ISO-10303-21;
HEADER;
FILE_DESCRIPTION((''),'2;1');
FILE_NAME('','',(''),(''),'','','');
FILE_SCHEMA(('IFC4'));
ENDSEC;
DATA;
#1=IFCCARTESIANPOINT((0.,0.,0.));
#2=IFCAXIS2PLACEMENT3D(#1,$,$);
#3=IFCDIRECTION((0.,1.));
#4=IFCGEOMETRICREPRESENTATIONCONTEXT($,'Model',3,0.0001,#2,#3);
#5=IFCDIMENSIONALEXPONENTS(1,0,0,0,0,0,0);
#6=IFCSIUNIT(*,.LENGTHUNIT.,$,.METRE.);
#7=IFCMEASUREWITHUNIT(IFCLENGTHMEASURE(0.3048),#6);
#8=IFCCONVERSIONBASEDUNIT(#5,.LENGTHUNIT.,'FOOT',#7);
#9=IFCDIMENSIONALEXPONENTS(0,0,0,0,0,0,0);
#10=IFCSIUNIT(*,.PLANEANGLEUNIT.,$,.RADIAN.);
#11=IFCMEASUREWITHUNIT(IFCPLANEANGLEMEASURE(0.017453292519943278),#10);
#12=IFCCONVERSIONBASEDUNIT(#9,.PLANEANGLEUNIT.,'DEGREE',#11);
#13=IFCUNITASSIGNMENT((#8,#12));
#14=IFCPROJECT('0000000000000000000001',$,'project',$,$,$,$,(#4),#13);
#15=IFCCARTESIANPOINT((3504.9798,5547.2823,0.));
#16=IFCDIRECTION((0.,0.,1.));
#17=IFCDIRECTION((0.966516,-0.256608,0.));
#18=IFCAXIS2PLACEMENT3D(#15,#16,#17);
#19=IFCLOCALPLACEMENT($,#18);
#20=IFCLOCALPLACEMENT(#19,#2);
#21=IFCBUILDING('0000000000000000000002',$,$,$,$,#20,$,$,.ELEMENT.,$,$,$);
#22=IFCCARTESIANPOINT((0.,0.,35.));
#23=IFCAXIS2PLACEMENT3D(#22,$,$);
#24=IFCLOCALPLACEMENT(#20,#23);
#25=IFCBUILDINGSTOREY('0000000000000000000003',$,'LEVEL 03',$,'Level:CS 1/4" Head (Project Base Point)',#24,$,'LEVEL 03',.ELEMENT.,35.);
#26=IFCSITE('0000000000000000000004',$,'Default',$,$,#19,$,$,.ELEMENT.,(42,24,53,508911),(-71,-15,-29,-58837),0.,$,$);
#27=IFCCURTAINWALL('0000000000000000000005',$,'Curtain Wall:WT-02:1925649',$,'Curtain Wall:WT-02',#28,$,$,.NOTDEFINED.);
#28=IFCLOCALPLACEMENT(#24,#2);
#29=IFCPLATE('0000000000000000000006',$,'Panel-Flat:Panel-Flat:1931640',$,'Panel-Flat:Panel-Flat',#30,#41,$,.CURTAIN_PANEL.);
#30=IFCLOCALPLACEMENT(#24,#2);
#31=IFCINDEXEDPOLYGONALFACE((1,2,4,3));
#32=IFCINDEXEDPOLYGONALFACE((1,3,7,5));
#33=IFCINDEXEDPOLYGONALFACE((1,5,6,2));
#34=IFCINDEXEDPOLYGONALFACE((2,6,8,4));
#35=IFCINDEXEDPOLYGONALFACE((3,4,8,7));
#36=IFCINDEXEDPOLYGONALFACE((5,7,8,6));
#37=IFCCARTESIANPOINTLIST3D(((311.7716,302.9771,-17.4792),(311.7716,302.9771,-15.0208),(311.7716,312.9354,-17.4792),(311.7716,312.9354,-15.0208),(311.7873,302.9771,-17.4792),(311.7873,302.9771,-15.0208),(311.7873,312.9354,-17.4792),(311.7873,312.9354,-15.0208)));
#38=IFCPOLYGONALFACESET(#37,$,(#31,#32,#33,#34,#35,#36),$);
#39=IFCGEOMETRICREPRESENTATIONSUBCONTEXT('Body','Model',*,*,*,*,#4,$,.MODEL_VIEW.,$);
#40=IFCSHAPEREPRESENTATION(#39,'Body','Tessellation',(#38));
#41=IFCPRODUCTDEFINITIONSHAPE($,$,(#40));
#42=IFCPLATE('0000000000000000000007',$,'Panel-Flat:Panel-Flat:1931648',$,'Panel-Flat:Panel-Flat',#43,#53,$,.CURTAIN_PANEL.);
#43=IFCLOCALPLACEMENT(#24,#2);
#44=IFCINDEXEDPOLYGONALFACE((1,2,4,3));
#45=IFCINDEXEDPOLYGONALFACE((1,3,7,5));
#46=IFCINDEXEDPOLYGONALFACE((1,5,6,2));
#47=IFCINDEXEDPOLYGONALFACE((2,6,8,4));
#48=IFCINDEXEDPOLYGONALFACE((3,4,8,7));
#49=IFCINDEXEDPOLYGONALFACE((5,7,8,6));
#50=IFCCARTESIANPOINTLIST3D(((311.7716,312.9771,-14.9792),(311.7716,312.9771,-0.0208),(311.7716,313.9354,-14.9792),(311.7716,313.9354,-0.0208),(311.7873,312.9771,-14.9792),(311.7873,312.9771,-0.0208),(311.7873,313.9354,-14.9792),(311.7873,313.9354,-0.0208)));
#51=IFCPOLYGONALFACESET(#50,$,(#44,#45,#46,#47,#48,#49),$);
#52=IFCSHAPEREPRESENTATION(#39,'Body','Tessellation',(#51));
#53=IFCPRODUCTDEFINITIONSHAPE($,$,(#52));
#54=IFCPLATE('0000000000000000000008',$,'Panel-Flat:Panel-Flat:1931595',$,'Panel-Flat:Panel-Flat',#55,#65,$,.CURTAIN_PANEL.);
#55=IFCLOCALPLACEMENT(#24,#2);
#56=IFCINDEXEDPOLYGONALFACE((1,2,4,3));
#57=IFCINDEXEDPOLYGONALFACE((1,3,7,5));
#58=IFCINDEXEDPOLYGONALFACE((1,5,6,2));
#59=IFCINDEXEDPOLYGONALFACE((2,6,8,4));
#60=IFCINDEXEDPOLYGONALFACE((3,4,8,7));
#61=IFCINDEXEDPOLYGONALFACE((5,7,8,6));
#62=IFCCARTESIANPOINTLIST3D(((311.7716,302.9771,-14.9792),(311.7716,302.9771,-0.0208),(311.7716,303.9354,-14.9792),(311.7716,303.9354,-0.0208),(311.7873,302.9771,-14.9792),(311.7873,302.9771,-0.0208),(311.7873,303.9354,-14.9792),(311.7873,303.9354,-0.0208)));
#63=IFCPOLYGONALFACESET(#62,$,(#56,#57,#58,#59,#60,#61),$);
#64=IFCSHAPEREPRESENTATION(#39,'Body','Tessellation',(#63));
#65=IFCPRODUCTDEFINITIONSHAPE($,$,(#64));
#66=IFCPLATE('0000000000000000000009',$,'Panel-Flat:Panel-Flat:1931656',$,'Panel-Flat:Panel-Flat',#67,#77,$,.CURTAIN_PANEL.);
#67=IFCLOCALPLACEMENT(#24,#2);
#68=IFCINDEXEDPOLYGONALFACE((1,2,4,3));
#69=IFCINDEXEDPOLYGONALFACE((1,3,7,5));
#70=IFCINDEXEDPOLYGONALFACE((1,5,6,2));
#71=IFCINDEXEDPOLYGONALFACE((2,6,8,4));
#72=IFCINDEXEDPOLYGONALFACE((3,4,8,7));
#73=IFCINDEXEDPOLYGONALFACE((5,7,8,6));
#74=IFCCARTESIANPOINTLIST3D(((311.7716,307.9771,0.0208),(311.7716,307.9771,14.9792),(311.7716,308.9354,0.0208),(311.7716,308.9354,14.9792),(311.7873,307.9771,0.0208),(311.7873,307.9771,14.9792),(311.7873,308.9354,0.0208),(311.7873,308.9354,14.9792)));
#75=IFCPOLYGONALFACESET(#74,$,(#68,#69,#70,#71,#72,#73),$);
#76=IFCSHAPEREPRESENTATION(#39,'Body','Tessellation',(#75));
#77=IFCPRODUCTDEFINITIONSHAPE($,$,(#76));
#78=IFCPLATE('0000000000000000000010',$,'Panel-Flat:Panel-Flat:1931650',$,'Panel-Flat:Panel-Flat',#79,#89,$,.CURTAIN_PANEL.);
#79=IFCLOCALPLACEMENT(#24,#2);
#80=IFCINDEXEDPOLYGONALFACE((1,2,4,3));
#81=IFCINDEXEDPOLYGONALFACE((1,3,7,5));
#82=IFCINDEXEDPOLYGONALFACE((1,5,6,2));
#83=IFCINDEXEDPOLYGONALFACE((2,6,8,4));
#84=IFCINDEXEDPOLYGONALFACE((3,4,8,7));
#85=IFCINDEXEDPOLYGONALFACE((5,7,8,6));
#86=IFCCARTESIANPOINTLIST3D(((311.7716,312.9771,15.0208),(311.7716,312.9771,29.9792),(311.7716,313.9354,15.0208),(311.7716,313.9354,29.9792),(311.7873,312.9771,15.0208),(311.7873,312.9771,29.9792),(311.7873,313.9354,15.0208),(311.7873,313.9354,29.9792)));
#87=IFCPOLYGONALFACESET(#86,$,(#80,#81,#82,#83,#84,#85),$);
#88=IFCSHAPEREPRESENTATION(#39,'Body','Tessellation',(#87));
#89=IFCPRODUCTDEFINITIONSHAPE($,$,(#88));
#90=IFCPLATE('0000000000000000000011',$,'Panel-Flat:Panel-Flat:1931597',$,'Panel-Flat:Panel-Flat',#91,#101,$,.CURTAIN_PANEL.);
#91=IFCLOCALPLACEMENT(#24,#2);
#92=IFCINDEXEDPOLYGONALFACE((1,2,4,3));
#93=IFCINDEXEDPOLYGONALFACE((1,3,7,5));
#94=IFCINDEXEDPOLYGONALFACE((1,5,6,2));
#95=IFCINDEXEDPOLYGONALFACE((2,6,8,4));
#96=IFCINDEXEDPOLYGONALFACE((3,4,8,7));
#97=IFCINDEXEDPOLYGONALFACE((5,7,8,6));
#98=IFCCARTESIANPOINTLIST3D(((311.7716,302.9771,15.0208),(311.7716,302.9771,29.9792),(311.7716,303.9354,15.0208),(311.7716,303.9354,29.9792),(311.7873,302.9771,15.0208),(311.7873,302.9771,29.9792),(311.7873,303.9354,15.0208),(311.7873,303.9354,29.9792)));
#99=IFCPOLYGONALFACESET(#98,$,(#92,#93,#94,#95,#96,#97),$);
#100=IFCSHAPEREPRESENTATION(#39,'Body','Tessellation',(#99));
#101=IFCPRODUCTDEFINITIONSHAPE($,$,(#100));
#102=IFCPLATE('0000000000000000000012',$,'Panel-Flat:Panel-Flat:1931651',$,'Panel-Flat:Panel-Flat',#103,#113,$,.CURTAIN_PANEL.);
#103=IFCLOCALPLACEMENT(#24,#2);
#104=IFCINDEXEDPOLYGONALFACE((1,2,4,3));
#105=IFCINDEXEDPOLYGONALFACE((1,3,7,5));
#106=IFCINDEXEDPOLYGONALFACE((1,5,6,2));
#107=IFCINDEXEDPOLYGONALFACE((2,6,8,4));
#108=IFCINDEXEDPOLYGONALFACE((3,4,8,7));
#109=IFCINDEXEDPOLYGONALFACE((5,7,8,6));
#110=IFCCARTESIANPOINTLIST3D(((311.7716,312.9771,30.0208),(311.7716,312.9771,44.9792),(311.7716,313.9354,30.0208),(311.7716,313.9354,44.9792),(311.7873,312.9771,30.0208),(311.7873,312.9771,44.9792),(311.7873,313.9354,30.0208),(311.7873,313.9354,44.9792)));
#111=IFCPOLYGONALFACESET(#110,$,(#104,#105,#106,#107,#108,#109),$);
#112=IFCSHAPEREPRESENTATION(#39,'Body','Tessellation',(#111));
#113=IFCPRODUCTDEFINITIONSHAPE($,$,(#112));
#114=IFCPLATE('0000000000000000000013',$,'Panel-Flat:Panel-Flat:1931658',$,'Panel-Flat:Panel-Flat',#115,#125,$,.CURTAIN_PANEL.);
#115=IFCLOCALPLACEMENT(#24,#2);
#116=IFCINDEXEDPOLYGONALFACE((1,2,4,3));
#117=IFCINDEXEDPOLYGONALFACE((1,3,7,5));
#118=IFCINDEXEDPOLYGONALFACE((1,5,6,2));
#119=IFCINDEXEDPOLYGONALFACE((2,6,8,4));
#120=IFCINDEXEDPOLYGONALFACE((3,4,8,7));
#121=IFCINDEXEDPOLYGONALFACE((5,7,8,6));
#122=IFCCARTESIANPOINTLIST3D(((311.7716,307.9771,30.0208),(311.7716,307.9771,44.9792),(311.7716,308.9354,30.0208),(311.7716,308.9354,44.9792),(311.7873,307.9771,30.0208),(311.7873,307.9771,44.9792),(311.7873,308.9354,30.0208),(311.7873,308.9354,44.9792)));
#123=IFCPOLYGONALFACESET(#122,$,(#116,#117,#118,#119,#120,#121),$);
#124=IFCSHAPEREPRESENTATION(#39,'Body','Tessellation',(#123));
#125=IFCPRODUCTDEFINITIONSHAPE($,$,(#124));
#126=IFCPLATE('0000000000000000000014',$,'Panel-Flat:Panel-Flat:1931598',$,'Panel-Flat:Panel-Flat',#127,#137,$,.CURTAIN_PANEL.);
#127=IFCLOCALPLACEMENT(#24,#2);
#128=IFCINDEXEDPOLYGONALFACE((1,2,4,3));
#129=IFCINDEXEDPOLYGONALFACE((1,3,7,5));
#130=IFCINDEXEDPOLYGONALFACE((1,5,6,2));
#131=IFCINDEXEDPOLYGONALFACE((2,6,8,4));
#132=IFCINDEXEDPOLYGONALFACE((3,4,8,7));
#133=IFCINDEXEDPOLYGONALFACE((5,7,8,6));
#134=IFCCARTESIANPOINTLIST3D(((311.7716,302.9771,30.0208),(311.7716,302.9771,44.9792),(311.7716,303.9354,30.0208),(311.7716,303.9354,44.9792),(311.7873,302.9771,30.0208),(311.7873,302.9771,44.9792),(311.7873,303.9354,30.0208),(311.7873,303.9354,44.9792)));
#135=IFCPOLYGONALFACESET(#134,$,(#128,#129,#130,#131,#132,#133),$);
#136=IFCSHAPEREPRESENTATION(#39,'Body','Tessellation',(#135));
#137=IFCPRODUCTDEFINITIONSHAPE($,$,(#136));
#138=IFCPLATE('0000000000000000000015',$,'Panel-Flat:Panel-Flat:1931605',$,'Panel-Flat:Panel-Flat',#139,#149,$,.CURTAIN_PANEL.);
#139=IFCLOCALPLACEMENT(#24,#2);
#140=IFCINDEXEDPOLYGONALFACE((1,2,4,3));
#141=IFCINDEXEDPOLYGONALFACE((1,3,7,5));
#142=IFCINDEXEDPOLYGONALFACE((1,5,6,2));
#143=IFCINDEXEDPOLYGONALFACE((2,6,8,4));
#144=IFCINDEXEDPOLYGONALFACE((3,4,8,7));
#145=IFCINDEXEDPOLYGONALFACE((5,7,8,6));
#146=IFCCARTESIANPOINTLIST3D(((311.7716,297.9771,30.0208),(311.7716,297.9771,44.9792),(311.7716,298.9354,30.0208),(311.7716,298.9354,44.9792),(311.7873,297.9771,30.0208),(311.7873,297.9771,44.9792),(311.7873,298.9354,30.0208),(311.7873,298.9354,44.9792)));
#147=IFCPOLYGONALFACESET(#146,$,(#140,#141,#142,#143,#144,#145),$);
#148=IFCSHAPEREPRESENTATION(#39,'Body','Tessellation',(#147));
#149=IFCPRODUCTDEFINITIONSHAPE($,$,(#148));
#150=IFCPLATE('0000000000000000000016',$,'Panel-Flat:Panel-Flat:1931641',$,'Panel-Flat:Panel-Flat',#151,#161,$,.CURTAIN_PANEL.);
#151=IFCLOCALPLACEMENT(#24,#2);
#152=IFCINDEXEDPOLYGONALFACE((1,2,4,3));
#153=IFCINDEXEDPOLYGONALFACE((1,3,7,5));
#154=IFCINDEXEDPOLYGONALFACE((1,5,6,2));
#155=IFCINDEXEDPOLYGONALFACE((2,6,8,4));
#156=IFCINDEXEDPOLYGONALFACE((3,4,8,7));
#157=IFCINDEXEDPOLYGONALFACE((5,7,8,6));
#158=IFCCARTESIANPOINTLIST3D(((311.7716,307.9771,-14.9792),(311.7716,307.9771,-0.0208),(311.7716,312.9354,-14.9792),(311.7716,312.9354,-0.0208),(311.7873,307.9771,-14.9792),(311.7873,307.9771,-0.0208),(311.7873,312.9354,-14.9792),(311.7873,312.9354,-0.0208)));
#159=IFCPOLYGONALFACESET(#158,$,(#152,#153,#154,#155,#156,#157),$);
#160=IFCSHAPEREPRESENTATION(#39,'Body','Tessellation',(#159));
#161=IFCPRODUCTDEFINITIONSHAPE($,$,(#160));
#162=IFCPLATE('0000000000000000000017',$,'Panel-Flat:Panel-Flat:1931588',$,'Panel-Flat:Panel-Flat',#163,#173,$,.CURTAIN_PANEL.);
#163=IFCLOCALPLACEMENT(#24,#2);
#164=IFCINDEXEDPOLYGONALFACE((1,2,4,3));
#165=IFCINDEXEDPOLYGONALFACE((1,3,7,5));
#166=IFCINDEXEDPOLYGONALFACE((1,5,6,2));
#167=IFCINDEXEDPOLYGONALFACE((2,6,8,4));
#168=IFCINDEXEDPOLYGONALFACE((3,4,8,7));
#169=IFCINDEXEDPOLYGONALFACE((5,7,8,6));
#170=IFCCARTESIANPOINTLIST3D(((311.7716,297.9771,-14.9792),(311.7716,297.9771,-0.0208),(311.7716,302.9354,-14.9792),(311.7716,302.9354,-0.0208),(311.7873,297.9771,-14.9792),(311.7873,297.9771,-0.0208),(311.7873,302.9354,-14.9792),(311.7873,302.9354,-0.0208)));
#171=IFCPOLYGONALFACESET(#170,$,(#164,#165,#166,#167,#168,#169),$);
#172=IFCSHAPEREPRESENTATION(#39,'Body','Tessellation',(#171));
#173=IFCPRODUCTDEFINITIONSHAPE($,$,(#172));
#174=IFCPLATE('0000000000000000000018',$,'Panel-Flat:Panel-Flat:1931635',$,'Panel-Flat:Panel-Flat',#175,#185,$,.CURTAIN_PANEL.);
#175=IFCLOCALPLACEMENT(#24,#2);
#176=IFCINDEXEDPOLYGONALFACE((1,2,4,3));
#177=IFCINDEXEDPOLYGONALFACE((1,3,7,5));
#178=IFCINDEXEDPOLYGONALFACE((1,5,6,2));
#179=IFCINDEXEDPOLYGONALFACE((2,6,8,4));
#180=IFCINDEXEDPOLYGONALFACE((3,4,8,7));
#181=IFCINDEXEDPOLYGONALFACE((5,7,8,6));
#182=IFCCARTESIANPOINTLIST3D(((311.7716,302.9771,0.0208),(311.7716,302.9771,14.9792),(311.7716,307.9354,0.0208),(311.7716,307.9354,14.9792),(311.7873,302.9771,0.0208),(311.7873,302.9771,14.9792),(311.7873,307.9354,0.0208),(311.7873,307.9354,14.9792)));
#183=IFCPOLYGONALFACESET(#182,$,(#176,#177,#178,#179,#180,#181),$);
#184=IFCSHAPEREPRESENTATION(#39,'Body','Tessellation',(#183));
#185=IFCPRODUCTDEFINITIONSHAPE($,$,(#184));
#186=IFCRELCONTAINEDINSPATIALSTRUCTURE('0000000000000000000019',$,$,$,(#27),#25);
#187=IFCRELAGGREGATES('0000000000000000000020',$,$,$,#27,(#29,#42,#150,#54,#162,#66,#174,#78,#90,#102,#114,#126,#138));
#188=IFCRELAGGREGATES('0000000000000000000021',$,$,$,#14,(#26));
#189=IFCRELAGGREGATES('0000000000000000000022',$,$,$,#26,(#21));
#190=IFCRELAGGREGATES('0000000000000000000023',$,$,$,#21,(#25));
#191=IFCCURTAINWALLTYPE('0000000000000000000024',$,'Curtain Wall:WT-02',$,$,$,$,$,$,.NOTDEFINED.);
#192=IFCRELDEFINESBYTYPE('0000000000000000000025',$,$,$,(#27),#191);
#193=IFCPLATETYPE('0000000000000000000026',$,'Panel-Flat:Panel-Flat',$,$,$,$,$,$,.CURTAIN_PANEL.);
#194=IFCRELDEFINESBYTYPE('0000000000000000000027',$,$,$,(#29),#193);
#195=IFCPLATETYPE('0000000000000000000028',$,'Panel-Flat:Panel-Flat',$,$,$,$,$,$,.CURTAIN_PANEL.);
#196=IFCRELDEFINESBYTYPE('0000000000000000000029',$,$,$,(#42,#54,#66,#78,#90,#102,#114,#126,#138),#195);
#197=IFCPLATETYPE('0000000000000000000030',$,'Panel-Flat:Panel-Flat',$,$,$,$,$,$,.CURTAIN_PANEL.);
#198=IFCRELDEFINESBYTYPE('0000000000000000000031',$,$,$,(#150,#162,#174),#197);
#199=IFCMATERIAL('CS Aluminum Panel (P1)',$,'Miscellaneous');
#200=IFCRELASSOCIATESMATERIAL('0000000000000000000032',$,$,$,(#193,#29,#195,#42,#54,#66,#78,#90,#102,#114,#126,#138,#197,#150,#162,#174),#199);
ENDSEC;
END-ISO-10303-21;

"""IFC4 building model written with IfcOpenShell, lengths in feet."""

from ifc_helpers import new_model, entity, si_unit, converted_unit, direction, frame, origin, place, context, subcontext, project, spatial, indexed_curve, outline, extrude, source, transform, mapped, material, type_object, type_shapes, element, aggregate, save


model = new_model("IFC4")

# Units and contexts
model_context = context("Model", 3, precision=0.0001, world=origin(), true_north=direction((0.0, 1.0)))
body_context = subcontext(model_context, "Body", "Model", "MODEL_VIEW")
ifc_project = project(units=[converted_unit("LENGTHUNIT", "FOOT", entity("IfcLengthMeasure", 0.3048), si_unit("LENGTHUNIT", "METRE"), dimensions=[1, 0, 0, 0, 0, 0, 0]), converted_unit("PLANEANGLEUNIT", "DEGREE", entity("IfcPlaneAngleMeasure", 0.017453292519943278), si_unit("PLANEANGLEUNIT", "RADIAN"), dimensions=[0, 0, 0, 0, 0, 0, 0])], contexts=[model_context])

# Site, building, storey
site_placement = place(None, frame((3504.9798, 5547.2823, 0.0), z_axis=(0.0, 0.0, 1.0), x_axis=(0.966516, -0.256608, 0.0)))
site = spatial("IfcSite", under=ifc_project, at=site_placement, Name="Default", CompositionType="ELEMENT", RefLatitude=(42, 24, 53, 508911), RefLongitude=(-71, -15, -29, -58837), RefElevation=0.0)
building_placement = place(site_placement, origin())
building = spatial("IfcBuilding", under=site, at=building_placement, CompositionType="ELEMENT")
storey_placement = place(building_placement, frame((0.0, 0.0, 35.0)))
storey = spatial("IfcBuildingStorey", under=building, at=storey_placement, Name="LEVEL 03", ObjectType="Level:CS 1/4\" Head (Project Base Point)", LongName="LEVEL 03", CompositionType="ELEMENT", Elevation=35.0)

# Curtain wall, plates
curtain_wall_type = type_object("IfcCurtainWallType", Name="Curtain Wall:WT-02", PredefinedType="NOTDEFINED")
curtain_wall_1_placement = place(storey_placement, frame((0.0, 0.0, -35.0)))
curtain_wall_1 = element("IfcCurtainWall", 1, at=curtain_wall_1_placement, inside=storey, type_object=curtain_wall_type, Name="Curtain Wall:WT-02:1925649", ObjectType="Curtain Wall:WT-02", PredefinedType="NOTDEFINED")
ifc_material_1 = material(Name="CS Aluminum Panel (P1)", Category="Miscellaneous")
plate_type_1 = type_object("IfcPlateType", Name="Panel-Flat:Panel-Flat", PredefinedType="CURTAIN_PANEL", material=ifc_material_1)
shared_shape_1 = source(origin(), body_context, "Body", "SweptSolid", [
    extrude(outline(indexed_curve([(-0.0078, -4.9792), (0.0078, -4.9792), (0.0078, 4.9792), (-0.0078, 4.9792), (-0.0078, -4.9792)], self_intersect=False)), frame((0.0, -0.0078, 0.0208), z_axis=(0.0, 0.0, 1.0), x_axis=(0.0, -1.0, 0.0)), (0.0, 0.0, 1.0), 2.4583),
])
type_shapes(plate_type_1, [shared_shape_1])
plate_1_placement = place(curtain_wall_1_placement, frame((311.7873, 307.9563, 17.5), z_axis=(0.0, 0.0, 1.0), x_axis=(0.0, -1.0, 0.0)))
plate_1 = element("IfcPlate", 2, at=plate_1_placement, type_object=plate_type_1, material=ifc_material_1, Name="Panel-Flat:Panel-Flat:1931640", ObjectType="Panel-Flat:Panel-Flat", PredefinedType="CURTAIN_PANEL", context=body_context, shape_type="MappedRepresentation", body=[
    mapped(shared_shape_1, transform((0.0, 0.0, 0.0), scale=1.0)),
])
plate_type_2 = type_object("IfcPlateType", Name="Panel-Flat:Panel-Flat", PredefinedType="CURTAIN_PANEL", material=ifc_material_1)
shared_shape_2 = source(origin(), body_context, "Body", "SweptSolid", [
    extrude(outline(indexed_curve([(-0.0078, -0.4792), (0.0078, -0.4792), (0.0078, 0.4792), (-0.0078, 0.4792), (-0.0078, -0.4792)], self_intersect=False)), frame((0.0, -0.0078, 0.0208), z_axis=(0.0, 0.0, 1.0), x_axis=(0.0, -1.0, 0.0)), (0.0, 0.0, 1.0), 14.9583),
])
type_shapes(plate_type_2, [shared_shape_2])
plate_2_placement = place(curtain_wall_1_placement, frame((311.7873, 313.4563, 20.0), z_axis=(0.0, 0.0, 1.0), x_axis=(0.0, -1.0, 0.0)))
plate_2 = element("IfcPlate", 3, at=plate_2_placement, type_object=plate_type_2, material=ifc_material_1, Name="Panel-Flat:Panel-Flat:1931648", ObjectType="Panel-Flat:Panel-Flat", PredefinedType="CURTAIN_PANEL", context=body_context, shape_type="MappedRepresentation", body=[
    mapped(shared_shape_2, transform((0.0, 0.0, 0.0), scale=1.0)),
])
plate_3_placement = place(curtain_wall_1_placement, frame((311.7873, 303.4563, 20.0), z_axis=(0.0, 0.0, 1.0), x_axis=(0.0, -1.0, 0.0)))
plate_3 = element("IfcPlate", 4, at=plate_3_placement, type_object=plate_type_2, material=ifc_material_1, Name="Panel-Flat:Panel-Flat:1931595", ObjectType="Panel-Flat:Panel-Flat", PredefinedType="CURTAIN_PANEL", context=body_context, shape_type="MappedRepresentation", body=[
    mapped(shared_shape_2, transform((0.0, 0.0, 0.0), scale=1.0)),
])
plate_4_placement = place(curtain_wall_1_placement, frame((311.7873, 308.4563, 35.0), z_axis=(0.0, 0.0, 1.0), x_axis=(0.0, -1.0, 0.0)))
plate_4 = element("IfcPlate", 5, at=plate_4_placement, type_object=plate_type_2, material=ifc_material_1, Name="Panel-Flat:Panel-Flat:1931656", ObjectType="Panel-Flat:Panel-Flat", PredefinedType="CURTAIN_PANEL", context=body_context, shape_type="MappedRepresentation", body=[
    mapped(shared_shape_2, transform((0.0, 0.0, 0.0), scale=1.0)),
])
plate_5_placement = place(curtain_wall_1_placement, frame((311.7873, 313.4563, 50.0), z_axis=(0.0, 0.0, 1.0), x_axis=(0.0, -1.0, 0.0)))
plate_5 = element("IfcPlate", 6, at=plate_5_placement, type_object=plate_type_2, material=ifc_material_1, Name="Panel-Flat:Panel-Flat:1931650", ObjectType="Panel-Flat:Panel-Flat", PredefinedType="CURTAIN_PANEL", context=body_context, shape_type="MappedRepresentation", body=[
    mapped(shared_shape_2, transform((0.0, 0.0, 0.0), scale=1.0)),
])
plate_6_placement = place(curtain_wall_1_placement, frame((311.7873, 303.4563, 50.0), z_axis=(0.0, 0.0, 1.0), x_axis=(0.0, -1.0, 0.0)))
plate_6 = element("IfcPlate", 7, at=plate_6_placement, type_object=plate_type_2, material=ifc_material_1, Name="Panel-Flat:Panel-Flat:1931597", ObjectType="Panel-Flat:Panel-Flat", PredefinedType="CURTAIN_PANEL", context=body_context, shape_type="MappedRepresentation", body=[
    mapped(shared_shape_2, transform((0.0, 0.0, 0.0), scale=1.0)),
])
plate_7_placement = place(curtain_wall_1_placement, frame((311.7873, 313.4563, 65.0), z_axis=(0.0, 0.0, 1.0), x_axis=(0.0, -1.0, 0.0)))
plate_7 = element("IfcPlate", 8, at=plate_7_placement, type_object=plate_type_2, material=ifc_material_1, Name="Panel-Flat:Panel-Flat:1931651", ObjectType="Panel-Flat:Panel-Flat", PredefinedType="CURTAIN_PANEL", context=body_context, shape_type="MappedRepresentation", body=[
    mapped(shared_shape_2, transform((0.0, 0.0, 0.0), scale=1.0)),
])
plate_8_placement = place(curtain_wall_1_placement, frame((311.7873, 308.4563, 65.0), z_axis=(0.0, 0.0, 1.0), x_axis=(0.0, -1.0, 0.0)))
plate_8 = element("IfcPlate", 9, at=plate_8_placement, type_object=plate_type_2, material=ifc_material_1, Name="Panel-Flat:Panel-Flat:1931658", ObjectType="Panel-Flat:Panel-Flat", PredefinedType="CURTAIN_PANEL", context=body_context, shape_type="MappedRepresentation", body=[
    mapped(shared_shape_2, transform((0.0, 0.0, 0.0), scale=1.0)),
])
plate_9_placement = place(curtain_wall_1_placement, frame((311.7873, 303.4563, 65.0), z_axis=(0.0, 0.0, 1.0), x_axis=(0.0, -1.0, 0.0)))
plate_9 = element("IfcPlate", 10, at=plate_9_placement, type_object=plate_type_2, material=ifc_material_1, Name="Panel-Flat:Panel-Flat:1931598", ObjectType="Panel-Flat:Panel-Flat", PredefinedType="CURTAIN_PANEL", context=body_context, shape_type="MappedRepresentation", body=[
    mapped(shared_shape_2, transform((0.0, 0.0, 0.0), scale=1.0)),
])
plate_10_placement = place(curtain_wall_1_placement, frame((311.7873, 298.4563, 65.0), z_axis=(0.0, 0.0, 1.0), x_axis=(0.0, -1.0, 0.0)))
plate_10 = element("IfcPlate", 11, at=plate_10_placement, type_object=plate_type_2, material=ifc_material_1, Name="Panel-Flat:Panel-Flat:1931605", ObjectType="Panel-Flat:Panel-Flat", PredefinedType="CURTAIN_PANEL", context=body_context, shape_type="MappedRepresentation", body=[
    mapped(shared_shape_2, transform((0.0, 0.0, 0.0), scale=1.0)),
])
plate_type_3 = type_object("IfcPlateType", Name="Panel-Flat:Panel-Flat", PredefinedType="CURTAIN_PANEL", material=ifc_material_1)
shared_shape_3 = source(origin(), body_context, "Body", "SweptSolid", [
    extrude(outline(indexed_curve([(-0.0078, -2.4792), (0.0078, -2.4792), (0.0078, 2.4792), (-0.0078, 2.4792), (-0.0078, -2.4792)], self_intersect=False)), frame((0.0, -0.0078, 0.0208), z_axis=(0.0, 0.0, 1.0), x_axis=(0.0, -1.0, 0.0)), (0.0, 0.0, 1.0), 14.9583),
])
type_shapes(plate_type_3, [shared_shape_3])
plate_11_placement = place(curtain_wall_1_placement, frame((311.7873, 310.4563, 20.0), z_axis=(0.0, 0.0, 1.0), x_axis=(0.0, -1.0, 0.0)))
plate_11 = element("IfcPlate", 12, at=plate_11_placement, type_object=plate_type_3, material=ifc_material_1, Name="Panel-Flat:Panel-Flat:1931641", ObjectType="Panel-Flat:Panel-Flat", PredefinedType="CURTAIN_PANEL", context=body_context, shape_type="MappedRepresentation", body=[
    mapped(shared_shape_3, transform((0.0, 0.0, 0.0), scale=1.0)),
])
plate_12_placement = place(curtain_wall_1_placement, frame((311.7873, 300.4563, 20.0), z_axis=(0.0, 0.0, 1.0), x_axis=(0.0, -1.0, 0.0)))
plate_12 = element("IfcPlate", 13, at=plate_12_placement, type_object=plate_type_3, material=ifc_material_1, Name="Panel-Flat:Panel-Flat:1931588", ObjectType="Panel-Flat:Panel-Flat", PredefinedType="CURTAIN_PANEL", context=body_context, shape_type="MappedRepresentation", body=[
    mapped(shared_shape_3, transform((0.0, 0.0, 0.0), scale=1.0)),
])
plate_13_placement = place(curtain_wall_1_placement, frame((311.7873, 305.4563, 35.0), z_axis=(0.0, 0.0, 1.0), x_axis=(0.0, -1.0, 0.0)))
plate_13 = element("IfcPlate", 14, at=plate_13_placement, type_object=plate_type_3, material=ifc_material_1, Name="Panel-Flat:Panel-Flat:1931635", ObjectType="Panel-Flat:Panel-Flat", PredefinedType="CURTAIN_PANEL", context=body_context, shape_type="MappedRepresentation", body=[
    mapped(shared_shape_3, transform((0.0, 0.0, 0.0), scale=1.0)),
])

aggregate(curtain_wall_1, [plate_1, plate_2, plate_11, plate_3, plate_12, plate_4, plate_13, plate_5, plate_6, plate_7, plate_8, plate_9, plate_10])

save(model, "model.ifc")
